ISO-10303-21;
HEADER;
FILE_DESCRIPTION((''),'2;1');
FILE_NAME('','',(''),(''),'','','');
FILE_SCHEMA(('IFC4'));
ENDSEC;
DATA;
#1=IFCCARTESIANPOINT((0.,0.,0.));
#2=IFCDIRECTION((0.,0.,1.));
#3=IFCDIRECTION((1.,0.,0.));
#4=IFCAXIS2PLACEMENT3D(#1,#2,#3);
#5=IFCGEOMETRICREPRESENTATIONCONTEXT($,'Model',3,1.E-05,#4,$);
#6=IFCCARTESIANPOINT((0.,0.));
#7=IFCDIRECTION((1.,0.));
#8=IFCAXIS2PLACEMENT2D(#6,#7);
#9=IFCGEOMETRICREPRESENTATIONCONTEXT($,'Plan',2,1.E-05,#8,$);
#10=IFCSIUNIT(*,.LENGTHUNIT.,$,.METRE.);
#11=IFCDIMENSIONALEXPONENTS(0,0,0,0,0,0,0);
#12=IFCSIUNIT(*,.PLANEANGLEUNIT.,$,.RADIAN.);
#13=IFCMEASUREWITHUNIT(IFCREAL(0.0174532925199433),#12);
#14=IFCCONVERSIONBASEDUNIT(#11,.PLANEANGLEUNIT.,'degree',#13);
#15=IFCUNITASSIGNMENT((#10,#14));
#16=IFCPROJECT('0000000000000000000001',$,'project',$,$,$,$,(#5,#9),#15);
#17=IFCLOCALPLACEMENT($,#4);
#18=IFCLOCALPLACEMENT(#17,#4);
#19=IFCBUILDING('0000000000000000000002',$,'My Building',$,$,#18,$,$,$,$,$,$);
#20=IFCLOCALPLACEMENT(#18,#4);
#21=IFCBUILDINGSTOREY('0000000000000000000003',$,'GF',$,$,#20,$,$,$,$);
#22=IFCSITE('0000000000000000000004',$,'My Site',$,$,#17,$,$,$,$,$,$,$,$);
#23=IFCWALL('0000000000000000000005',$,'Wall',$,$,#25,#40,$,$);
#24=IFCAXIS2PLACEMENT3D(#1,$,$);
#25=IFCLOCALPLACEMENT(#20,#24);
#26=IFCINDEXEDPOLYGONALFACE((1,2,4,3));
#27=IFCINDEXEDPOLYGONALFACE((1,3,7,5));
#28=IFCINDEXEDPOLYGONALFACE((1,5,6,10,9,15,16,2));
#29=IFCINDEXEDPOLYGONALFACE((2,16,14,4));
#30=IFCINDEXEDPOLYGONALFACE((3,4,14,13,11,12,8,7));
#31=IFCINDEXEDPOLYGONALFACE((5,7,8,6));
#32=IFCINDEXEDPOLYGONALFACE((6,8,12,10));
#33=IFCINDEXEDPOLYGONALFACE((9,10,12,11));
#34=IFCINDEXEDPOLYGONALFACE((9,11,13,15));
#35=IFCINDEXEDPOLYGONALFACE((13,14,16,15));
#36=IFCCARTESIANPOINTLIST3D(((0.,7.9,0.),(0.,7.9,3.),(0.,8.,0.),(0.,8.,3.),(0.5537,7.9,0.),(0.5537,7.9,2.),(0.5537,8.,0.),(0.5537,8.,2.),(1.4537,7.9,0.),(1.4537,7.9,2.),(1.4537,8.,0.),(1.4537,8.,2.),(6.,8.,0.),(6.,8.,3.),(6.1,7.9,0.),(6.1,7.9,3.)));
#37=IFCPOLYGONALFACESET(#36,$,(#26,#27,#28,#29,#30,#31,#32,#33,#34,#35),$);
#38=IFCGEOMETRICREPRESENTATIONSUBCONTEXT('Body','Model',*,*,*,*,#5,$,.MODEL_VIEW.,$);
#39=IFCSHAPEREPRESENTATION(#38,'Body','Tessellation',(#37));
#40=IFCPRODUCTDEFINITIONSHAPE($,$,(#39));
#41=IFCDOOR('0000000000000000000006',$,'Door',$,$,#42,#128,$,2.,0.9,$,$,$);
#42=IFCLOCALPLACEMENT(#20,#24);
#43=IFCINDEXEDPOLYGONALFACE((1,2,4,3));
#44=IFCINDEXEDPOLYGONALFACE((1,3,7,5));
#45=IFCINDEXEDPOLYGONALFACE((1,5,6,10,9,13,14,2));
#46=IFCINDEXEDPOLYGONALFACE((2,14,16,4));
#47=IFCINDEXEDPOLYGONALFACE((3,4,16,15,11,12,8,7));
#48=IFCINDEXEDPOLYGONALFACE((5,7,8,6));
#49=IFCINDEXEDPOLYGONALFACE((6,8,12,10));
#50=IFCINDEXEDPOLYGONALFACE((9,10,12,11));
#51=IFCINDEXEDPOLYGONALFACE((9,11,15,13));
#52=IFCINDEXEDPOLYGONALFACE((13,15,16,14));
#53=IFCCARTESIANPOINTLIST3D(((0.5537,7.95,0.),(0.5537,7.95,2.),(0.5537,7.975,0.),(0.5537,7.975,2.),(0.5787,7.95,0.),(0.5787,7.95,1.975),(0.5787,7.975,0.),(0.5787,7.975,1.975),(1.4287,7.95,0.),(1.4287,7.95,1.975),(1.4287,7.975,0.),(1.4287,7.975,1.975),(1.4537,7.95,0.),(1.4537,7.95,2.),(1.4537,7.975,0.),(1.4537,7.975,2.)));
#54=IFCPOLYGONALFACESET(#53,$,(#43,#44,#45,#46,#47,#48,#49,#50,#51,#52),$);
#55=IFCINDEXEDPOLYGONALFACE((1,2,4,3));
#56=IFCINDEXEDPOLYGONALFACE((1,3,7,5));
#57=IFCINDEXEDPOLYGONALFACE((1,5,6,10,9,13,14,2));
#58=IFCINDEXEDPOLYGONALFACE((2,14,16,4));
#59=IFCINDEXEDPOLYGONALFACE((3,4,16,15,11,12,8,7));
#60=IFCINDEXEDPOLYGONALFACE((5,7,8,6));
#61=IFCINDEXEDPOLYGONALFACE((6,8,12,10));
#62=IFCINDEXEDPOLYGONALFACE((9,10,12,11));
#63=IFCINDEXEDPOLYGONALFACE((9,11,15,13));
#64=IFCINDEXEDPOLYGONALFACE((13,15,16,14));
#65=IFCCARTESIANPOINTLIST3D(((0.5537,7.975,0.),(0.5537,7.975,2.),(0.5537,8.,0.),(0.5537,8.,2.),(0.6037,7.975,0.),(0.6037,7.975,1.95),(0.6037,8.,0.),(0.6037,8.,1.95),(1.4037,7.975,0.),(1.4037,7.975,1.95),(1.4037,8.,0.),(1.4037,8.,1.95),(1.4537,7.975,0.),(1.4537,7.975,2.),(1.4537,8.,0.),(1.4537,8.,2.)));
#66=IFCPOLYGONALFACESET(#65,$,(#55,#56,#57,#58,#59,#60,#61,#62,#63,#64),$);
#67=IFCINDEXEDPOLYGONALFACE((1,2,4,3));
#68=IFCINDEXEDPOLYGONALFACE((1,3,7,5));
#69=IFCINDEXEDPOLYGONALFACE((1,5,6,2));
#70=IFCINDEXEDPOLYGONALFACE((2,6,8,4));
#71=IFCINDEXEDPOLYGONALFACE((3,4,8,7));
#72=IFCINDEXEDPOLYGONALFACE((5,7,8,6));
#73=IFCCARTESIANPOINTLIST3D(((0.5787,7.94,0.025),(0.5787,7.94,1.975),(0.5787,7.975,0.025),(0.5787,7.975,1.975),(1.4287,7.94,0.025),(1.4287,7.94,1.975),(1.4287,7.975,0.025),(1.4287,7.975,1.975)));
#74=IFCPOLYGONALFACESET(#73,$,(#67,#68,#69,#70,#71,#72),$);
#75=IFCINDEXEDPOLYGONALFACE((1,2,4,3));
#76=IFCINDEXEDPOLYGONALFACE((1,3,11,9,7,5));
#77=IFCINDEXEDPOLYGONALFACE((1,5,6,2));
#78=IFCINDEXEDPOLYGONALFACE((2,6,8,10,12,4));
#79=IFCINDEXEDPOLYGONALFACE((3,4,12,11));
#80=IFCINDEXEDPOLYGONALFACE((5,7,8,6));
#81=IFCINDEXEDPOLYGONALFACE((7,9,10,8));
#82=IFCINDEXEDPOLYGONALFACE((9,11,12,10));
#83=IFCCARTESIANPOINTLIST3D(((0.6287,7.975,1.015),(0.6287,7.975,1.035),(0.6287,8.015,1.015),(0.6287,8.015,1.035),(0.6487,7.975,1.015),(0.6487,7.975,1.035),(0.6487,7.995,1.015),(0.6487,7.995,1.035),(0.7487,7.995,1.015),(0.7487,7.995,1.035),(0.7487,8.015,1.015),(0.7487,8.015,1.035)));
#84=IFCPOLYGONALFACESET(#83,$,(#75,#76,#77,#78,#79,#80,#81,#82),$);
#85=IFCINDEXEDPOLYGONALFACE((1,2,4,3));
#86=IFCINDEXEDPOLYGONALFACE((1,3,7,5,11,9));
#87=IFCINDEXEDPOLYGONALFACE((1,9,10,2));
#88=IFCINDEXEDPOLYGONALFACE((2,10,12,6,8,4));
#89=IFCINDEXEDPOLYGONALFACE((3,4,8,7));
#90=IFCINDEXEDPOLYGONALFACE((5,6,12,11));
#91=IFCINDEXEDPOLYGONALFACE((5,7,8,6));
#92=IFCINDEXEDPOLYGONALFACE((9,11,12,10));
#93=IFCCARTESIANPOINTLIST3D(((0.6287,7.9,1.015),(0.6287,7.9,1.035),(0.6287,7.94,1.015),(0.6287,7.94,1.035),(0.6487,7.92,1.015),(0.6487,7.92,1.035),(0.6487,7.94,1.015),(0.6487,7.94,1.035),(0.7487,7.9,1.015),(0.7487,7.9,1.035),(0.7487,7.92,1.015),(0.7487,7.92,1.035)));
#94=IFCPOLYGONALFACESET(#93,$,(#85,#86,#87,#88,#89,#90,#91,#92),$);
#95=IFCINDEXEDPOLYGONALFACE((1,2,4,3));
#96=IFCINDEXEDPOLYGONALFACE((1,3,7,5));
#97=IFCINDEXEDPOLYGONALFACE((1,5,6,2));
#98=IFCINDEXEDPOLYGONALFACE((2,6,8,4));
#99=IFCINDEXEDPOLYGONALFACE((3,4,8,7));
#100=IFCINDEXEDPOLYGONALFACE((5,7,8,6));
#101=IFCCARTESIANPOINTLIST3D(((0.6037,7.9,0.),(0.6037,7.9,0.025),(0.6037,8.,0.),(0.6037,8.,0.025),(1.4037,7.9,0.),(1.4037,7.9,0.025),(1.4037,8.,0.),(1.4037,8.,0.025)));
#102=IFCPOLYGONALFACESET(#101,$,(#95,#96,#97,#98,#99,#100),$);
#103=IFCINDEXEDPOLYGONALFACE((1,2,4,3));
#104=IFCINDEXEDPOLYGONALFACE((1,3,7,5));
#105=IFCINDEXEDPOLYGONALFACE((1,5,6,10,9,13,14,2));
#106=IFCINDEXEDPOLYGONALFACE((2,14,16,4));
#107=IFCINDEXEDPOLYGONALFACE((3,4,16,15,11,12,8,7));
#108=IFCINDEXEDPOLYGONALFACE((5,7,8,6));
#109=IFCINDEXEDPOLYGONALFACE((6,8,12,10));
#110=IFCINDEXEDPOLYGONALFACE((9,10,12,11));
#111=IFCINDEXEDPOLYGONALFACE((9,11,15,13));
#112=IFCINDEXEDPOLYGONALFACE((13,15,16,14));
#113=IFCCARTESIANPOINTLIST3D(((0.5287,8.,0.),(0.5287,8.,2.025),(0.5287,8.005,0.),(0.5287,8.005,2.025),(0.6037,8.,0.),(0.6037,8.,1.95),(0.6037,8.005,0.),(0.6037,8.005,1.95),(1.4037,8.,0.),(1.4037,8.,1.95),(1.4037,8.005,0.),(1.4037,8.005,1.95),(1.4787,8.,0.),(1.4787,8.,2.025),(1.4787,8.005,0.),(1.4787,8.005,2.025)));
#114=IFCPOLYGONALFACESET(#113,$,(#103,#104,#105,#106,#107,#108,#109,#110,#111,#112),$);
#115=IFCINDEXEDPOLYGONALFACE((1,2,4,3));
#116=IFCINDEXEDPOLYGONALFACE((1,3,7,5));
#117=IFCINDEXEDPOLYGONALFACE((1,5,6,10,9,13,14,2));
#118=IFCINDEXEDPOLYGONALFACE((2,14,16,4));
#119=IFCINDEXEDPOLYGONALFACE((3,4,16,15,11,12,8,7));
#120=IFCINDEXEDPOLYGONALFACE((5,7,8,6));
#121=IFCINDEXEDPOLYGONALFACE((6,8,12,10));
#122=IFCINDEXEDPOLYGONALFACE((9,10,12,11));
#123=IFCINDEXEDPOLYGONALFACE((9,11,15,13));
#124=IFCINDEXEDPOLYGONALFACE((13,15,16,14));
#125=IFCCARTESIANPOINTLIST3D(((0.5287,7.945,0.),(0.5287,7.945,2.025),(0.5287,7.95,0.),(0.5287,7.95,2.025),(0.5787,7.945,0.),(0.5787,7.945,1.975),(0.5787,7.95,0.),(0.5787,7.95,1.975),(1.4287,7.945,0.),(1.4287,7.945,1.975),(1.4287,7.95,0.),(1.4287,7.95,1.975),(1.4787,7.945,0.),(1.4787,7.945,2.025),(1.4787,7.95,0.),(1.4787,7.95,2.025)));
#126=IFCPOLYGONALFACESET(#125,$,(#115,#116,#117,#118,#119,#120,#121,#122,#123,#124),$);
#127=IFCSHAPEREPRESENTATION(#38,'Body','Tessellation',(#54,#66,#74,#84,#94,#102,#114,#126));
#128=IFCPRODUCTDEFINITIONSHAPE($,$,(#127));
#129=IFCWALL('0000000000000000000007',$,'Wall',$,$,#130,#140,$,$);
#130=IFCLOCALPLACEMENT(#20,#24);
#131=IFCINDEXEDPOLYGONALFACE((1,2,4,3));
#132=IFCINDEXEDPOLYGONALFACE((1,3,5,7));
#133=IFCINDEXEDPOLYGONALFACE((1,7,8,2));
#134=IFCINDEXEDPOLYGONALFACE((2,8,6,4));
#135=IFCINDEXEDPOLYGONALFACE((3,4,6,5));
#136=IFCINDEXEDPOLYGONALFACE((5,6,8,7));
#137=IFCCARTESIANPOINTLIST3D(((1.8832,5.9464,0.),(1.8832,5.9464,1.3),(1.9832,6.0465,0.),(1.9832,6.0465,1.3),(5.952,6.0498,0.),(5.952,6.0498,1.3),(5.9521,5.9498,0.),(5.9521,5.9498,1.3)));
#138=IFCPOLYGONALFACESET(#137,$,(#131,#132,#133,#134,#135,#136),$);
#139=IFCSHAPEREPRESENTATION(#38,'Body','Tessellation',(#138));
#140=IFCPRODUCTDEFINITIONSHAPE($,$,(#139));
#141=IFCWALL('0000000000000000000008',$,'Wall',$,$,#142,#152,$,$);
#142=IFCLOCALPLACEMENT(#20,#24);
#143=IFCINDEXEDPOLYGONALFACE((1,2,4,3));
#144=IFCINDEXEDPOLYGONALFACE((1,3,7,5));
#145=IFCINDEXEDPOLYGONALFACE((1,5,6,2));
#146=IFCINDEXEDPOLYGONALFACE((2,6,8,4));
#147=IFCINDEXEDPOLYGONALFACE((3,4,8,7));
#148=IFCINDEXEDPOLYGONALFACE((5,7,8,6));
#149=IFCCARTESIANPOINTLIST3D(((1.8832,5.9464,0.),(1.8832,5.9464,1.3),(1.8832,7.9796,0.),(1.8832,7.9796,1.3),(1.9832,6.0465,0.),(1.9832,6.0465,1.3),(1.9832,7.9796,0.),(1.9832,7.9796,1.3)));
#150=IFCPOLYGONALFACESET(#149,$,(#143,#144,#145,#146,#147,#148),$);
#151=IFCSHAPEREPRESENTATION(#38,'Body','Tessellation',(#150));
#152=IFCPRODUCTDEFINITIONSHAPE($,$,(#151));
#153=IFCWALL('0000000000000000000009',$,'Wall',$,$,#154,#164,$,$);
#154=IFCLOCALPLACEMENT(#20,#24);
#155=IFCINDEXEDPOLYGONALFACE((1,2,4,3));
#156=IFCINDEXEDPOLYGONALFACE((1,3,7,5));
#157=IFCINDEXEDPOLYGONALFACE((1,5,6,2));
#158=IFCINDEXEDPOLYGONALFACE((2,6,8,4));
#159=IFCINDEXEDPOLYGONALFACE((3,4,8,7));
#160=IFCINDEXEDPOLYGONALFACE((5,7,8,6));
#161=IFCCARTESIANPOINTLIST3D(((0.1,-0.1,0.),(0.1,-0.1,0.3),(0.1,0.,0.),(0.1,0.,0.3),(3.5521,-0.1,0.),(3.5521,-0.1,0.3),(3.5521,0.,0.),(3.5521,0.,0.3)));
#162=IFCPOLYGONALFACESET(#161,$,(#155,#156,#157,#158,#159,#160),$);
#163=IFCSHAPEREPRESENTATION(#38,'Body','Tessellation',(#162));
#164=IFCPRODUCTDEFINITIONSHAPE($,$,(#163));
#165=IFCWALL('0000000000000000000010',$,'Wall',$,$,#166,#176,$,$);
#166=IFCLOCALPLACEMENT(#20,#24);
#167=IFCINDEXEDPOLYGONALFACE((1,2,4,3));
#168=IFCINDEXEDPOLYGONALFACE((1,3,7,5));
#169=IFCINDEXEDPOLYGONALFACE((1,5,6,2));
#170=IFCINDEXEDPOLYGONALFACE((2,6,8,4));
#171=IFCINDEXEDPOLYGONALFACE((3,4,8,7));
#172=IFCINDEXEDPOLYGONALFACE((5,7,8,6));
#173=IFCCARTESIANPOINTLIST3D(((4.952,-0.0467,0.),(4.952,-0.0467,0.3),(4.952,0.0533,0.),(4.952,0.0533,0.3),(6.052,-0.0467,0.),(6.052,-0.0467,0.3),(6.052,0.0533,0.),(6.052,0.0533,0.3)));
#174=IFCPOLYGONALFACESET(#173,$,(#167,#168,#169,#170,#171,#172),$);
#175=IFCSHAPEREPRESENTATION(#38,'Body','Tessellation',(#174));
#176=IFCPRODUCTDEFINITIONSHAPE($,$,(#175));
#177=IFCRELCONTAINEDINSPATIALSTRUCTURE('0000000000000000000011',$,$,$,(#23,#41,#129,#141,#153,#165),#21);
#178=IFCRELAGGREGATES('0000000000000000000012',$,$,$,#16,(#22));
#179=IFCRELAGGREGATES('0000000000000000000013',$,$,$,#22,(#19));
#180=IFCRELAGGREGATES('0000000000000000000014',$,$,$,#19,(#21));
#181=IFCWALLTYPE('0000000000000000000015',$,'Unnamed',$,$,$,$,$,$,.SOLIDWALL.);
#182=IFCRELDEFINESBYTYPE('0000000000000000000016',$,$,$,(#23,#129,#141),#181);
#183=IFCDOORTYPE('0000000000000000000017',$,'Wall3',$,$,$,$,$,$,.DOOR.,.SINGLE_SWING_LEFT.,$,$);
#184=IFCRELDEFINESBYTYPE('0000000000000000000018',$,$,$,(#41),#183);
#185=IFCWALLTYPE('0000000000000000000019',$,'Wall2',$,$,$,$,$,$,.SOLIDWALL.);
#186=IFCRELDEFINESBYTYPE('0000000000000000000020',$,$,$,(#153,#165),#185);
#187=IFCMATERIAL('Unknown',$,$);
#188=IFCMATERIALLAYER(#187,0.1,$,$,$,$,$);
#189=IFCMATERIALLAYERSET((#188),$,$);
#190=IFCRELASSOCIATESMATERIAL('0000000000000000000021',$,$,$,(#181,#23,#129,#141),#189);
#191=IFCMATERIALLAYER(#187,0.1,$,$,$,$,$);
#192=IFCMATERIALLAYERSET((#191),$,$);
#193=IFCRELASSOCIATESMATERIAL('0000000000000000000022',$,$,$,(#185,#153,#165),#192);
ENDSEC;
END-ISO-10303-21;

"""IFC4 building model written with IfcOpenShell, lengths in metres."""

from ifc_helpers import new_model, entity, si_unit, converted_unit, frame, origin_with_axes, origin_2d_with_axis, place, context, subcontext, project, spatial, line, indexed_curve, outline, extrude, shape, source, transform, mapped, material, layer, layer_set, layer_usage, type_object, type_shapes, element, fill, save


model = new_model("IFC4")

# Units and contexts
model_context = context("Model", 3, precision=1e-05, world=origin_with_axes())
plan_context = context("Plan", 2, precision=1e-05, world=origin_2d_with_axis())
body_context_1 = subcontext(model_context, "Body", "Model", "MODEL_VIEW")
body_context_2 = subcontext(plan_context, "Body", "Plan", "PLAN_VIEW")
ifc_project = project(units=[si_unit("LENGTHUNIT", "METRE"), converted_unit("PLANEANGLEUNIT", "degree", entity("IfcReal", 0.0174532925199433), si_unit("PLANEANGLEUNIT", "RADIAN"), dimensions=[0, 0, 0, 0, 0, 0, 0])], contexts=[model_context, plan_context])

# Site, building, storey
site_placement = place(None, origin_with_axes())
site = spatial("IfcSite", under=ifc_project, at=site_placement, Name="My Site")
building_placement = place(site_placement, origin_with_axes())
building = spatial("IfcBuilding", under=site, at=building_placement, Name="My Building")
storey_placement = place(building_placement, origin_with_axes())
storey = spatial("IfcBuildingStorey", under=building, at=storey_placement, Name="GF")

# Shared definitions
ifc_material = material(Name="Unknown")

# Shared definitions
ifc_layer_1 = layer(ifc_material, 0.1)
ifc_layer_set_1 = layer_set([ifc_layer_1])
wall_type_1 = type_object("IfcWallType", Name="Unnamed", PredefinedType="SOLIDWALL", material=ifc_layer_set_1)

# Wall, opening, door
ifc_layer_usage_1 = layer_usage(ifc_layer_set_1, "AXIS2", "POSITIVE", 0.0)
wall_1_placement = place(storey_placement, frame((6.0, 8.0, 0.0), z_axis=(0.0, 0.0, 1.0), x_axis=(-1.0, 0.0, 0.0)))
wall_1 = element("IfcWall", 1, at=wall_1_placement, inside=storey, type_object=wall_type_1, material=ifc_layer_usage_1, Name="Wall", context=body_context_1, shape_type="SweptSolid", body=[
    extrude(outline(indexed_curve([(0.0, 0.0), (-0.1, 0.1), (6.0, 0.1), (6.0, 0.0)], segments=[line(1, 2, 3, 4, 1)])), origin_with_axes(), (0.0, 0.0, 1.0), 3.0),
])
shared_shape_1 = source(origin_with_axes(), body_context_1, "Body", "SweptSolid", [
    extrude(outline(indexed_curve([(0.0, 0.0), (0.9, 0.0), (0.9, 2.0), (0.0, 2.0)], segments=[line(1, 2, 3, 4, 1)])), frame((0.0, -0.6, 0.0), z_axis=(0.0, -1.0, 0.0), x_axis=(1.0, 0.0, 0.0)), (0.0, 0.0, -1.0), 1.2),
])
opening_placement = place(wall_1_placement, frame((4.5463, 0.0, 0.0), z_axis=(0.0, 0.0, 1.0), x_axis=(1.0, 0.0, 0.0)))
opening = element("IfcOpeningElement", 2, at=opening_placement, cuts=wall_1, PredefinedType="OPENING", context=body_context_1, shape_type="MappedRepresentation", body=[
    mapped(shared_shape_1, transform((0.0, 0.0, 0.0), x_axis=(1.0, 0.0, 0.0), y_axis=(0.0, 1.0, 0.0), z_axis=(0.0, 0.0, 1.0), scale=1.0)),
])
door_type = type_object("IfcDoorType", Name="Wall3", OperationType="SINGLE_SWING_LEFT", PredefinedType="DOOR")
shared_shape_2 = source(origin_with_axes(), body_context_1, "Body", "SweptSolid", [
    extrude(outline(indexed_curve([(0.0, 0.0), (0.0, 2.0), (0.9, 2.0), (0.9, 0.0), (0.875, 0.0), (0.875, 1.975), (0.025, 1.975), (0.025, 0.0)], segments=[line(1, 2, 3, 4, 5, 6, 7, 8, 1)])), frame((0.0, 0.025, 0.0), z_axis=(0.0, -1.0, 0.0), x_axis=(1.0, 0.0, 0.0)), (0.0, 0.0, -1.0), 0.025),
    extrude(outline(indexed_curve([(0.0, 0.0), (0.0, 2.0), (0.9, 2.0), (0.9, 0.0), (0.85, 0.0), (0.85, 1.95), (0.05, 1.95), (0.05, 0.0)], segments=[line(1, 2, 3, 4, 5, 6, 7, 8, 1)])), frame((0.0, 0.0, 0.0), z_axis=(0.0, -1.0, 0.0), x_axis=(1.0, 0.0, 0.0)), (0.0, 0.0, -1.0), 0.025),
    extrude(outline(indexed_curve([(0.0, 0.0), (0.85, 0.0), (0.85, 0.035), (0.0, 0.035)], segments=[line(1, 2, 3, 4, 1)])), frame((0.025, 0.025, 0.025), z_axis=(0.0, 0.0, 1.0), x_axis=(1.0, 0.0, 0.0)), (0.0, 0.0, 1.0), 1.95),
    extrude(outline(indexed_curve([(0.0, 0.0), (0.0, -0.04), (-0.12, -0.04), (-0.12, -0.02), (-0.02, -0.02), (-0.02, 0.0)], segments=[line(1, 2, 3, 4, 5, 6, 1)])), frame((0.825, 0.025, 1.015), z_axis=(0.0, 0.0, 1.0), x_axis=(1.0, 0.0, 0.0)), (0.0, 0.0, 1.0), 0.02),
    extrude(outline(indexed_curve([(0.0, 0.0), (0.0, 0.04), (-0.12, 0.04), (-0.12, 0.02), (-0.02, 0.02), (-0.02, 0.0)], segments=[line(1, 2, 3, 4, 5, 6, 1)])), frame((0.825, 0.06, 1.015), z_axis=(0.0, 0.0, 1.0), x_axis=(1.0, 0.0, 0.0)), (0.0, 0.0, 1.0), 0.02),
    extrude(outline(indexed_curve([(0.0, 0.0), (0.8, 0.0), (0.8, 0.1), (0.0, 0.1)], segments=[line(1, 2, 3, 4, 1)])), frame((0.05, 0.0, 0.0), z_axis=(0.0, 0.0, 1.0), x_axis=(1.0, 0.0, 0.0)), (0.0, 0.0, 1.0), 0.025),
    extrude(outline(indexed_curve([(0.0, 0.0), (0.0, 2.025), (0.95, 2.025), (0.95, 0.0), (0.875, 0.0), (0.875, 1.95), (0.075, 1.95), (0.075, 0.0)], segments=[line(1, 2, 3, 4, 5, 6, 7, 8, 1)])), frame((-0.025, -0.005, 0.0), z_axis=(0.0, -1.0, 0.0), x_axis=(1.0, 0.0, 0.0)), (0.0, 0.0, -1.0), 0.005),
    extrude(outline(indexed_curve([(0.0, 0.0), (0.0, 2.025), (0.95, 2.025), (0.95, 0.0), (0.9, 0.0), (0.9, 1.975), (0.05, 1.975), (0.05, 0.0)], segments=[line(1, 2, 3, 4, 5, 6, 7, 8, 1)])), frame((-0.025, 0.05, 0.0), z_axis=(0.0, -1.0, 0.0), x_axis=(1.0, 0.0, 0.0)), (0.0, 0.0, -1.0), 0.005),
])
shared_shape_3 = source(origin_with_axes(), body_context_2, "Body", "Curve2D", [
    entity("IfcIndexedPolyCurve", entity("IfcCartesianPointList2D", [[0.0, 0.0], [0.0, 0.05], [0.025, 0.05], [0.025, 0.025], [0.05, 0.025], [0.05, 0.0]]), [entity("IfcLineIndex", [1, 2, 3, 4, 5, 6, 1])]),
    entity("IfcIndexedPolyCurve", entity("IfcCartesianPointList2D", [[0.9, 0.0], [0.9, 0.05], [0.875, 0.05], [0.875, 0.025], [0.85, 0.025], [0.85, 0.0]]), [entity("IfcLineIndex", [1, 2, 3, 4, 5, 6, 1])]),
    entity("IfcTrimmedCurve", entity("IfcEllipse", entity("IfcAxis2Placement2D", entity("IfcCartesianPoint", [0.06, 0.05]), entity("IfcDirection", [1.0, 0.0])), 0.815, 0.85), [entity("IfcCartesianPoint", [0.875, 0.05])], [entity("IfcCartesianPoint", [0.06, 0.9])], True, "CARTESIAN"),
    entity("IfcIndexedPolyCurve", entity("IfcCartesianPointList2D", [[0.025, 0.05], [0.06, 0.05], [0.06, 0.9], [0.025, 0.9]]), [entity("IfcLineIndex", [1, 2, 3, 4, 1])]),
])
type_shapes(door_type, [shared_shape_2, shared_shape_3])
door_placement = place(opening_placement, frame((0.0, 0.0, 0.0), z_axis=(0.0, 0.0, 1.0), x_axis=(1.0, 0.0, 0.0)))
door = element("IfcDoor", 3, at=door_placement, inside=storey, type_object=door_type, Name="Door", OverallHeight=2.0, OverallWidth=0.9, shapes=[
    shape(body_context_1, "Body", "MappedRepresentation", [mapped(shared_shape_2, transform((0.0, 0.0, 0.0), x_axis=(1.0, 0.0, 0.0), y_axis=(0.0, 1.0, 0.0), z_axis=(0.0, 0.0, 1.0), scale=1.0))]),
    shape(body_context_2, "Body", "MappedRepresentation", [mapped(shared_shape_3, transform((0.0, 0.0, 0.0), x_axis=(1.0, 0.0, 0.0), y_axis=(0.0, 1.0, 0.0), z_axis=(0.0, 0.0, 1.0), scale=1.0))]),
])
fill(opening, door)

# Walls
ifc_layer_usage_2 = layer_usage(ifc_layer_set_1, "AXIS2", "POSITIVE", 0.0)
wall_2_placement = place(storey_placement, frame((5.952, 6.0498, 0.0), z_axis=(0.0, 0.0, 1.0), x_axis=(-1.0, -0.000833, 0.0)))
element("IfcWall", 4, at=wall_2_placement, inside=storey, type_object=wall_type_1, material=ifc_layer_usage_2, Name="Wall", context=body_context_1, shape_type="SweptSolid", body=[
    extrude(outline(indexed_curve([(0.0, 0.0), (0.0, 0.1), (4.0689, 0.1), (3.9688, 0.0)], segments=[line(1, 2, 3, 4, 1)])), origin_with_axes(), (0.0, 0.0, 1.0), 1.3),
])
ifc_layer_usage_3 = layer_usage(ifc_layer_set_1, "AXIS2", "POSITIVE", 0.0)
wall_3_placement = place(storey_placement, frame((1.9832, 6.0465, 0.0), z_axis=(0.0, 0.0, 1.0), x_axis=(0.0, 1.0, 0.0)))
element("IfcWall", 5, at=wall_3_placement, inside=storey, type_object=wall_type_1, material=ifc_layer_usage_3, Name="Wall", context=body_context_1, shape_type="SweptSolid", body=[
    extrude(outline(indexed_curve([(0.0, 0.0), (-0.1001, 0.1), (1.9331, 0.1), (1.9331, 0.0)], segments=[line(1, 2, 3, 4, 1)])), origin_with_axes(), (0.0, 0.0, 1.0), 1.3),
])
ifc_layer_2 = layer(ifc_material, 0.1)
ifc_layer_set_2 = layer_set([ifc_layer_2])
ifc_layer_usage_4 = layer_usage(ifc_layer_set_2, "AXIS2", "POSITIVE", 0.0)
wall_type_2 = type_object("IfcWallType", Name="Wall2", PredefinedType="SOLIDWALL", material=ifc_layer_set_2)
wall_4_placement = place(storey_placement, frame((0.1, -0.1, 0.0), z_axis=(0.0, 0.0, 1.0), x_axis=(1.0, 0.0, 0.0)))
element("IfcWall", 6, at=wall_4_placement, inside=storey, type_object=wall_type_2, material=ifc_layer_usage_4, Name="Wall", context=body_context_1, shape_type="SweptSolid", body=[
    extrude(outline(indexed_curve([(0.0, 0.0), (0.0, 0.1), (3.4521, 0.1), (3.4521, 0.0)], segments=[line(1, 2, 3, 4, 1)])), origin_with_axes(), (0.0, 0.0, 1.0), 0.3),
])
ifc_layer_usage_5 = layer_usage(ifc_layer_set_2, "AXIS2", "POSITIVE", 0.0)
wall_5_placement = place(storey_placement, frame((4.952, -0.0467, 0.0), z_axis=(0.0, 0.0, 1.0), x_axis=(1.0, 0.0, 0.0)))
element("IfcWall", 7, at=wall_5_placement, inside=storey, type_object=wall_type_2, material=ifc_layer_usage_5, Name="Wall", context=body_context_1, shape_type="SweptSolid", body=[
    extrude(outline(indexed_curve([(0.0, 0.0), (0.0, 0.1), (1.1, 0.1), (1.1, 0.0)], segments=[line(1, 2, 3, 4, 1)])), origin_with_axes(), (0.0, 0.0, 1.0), 0.3),
])

save(model, "model.ifc")
